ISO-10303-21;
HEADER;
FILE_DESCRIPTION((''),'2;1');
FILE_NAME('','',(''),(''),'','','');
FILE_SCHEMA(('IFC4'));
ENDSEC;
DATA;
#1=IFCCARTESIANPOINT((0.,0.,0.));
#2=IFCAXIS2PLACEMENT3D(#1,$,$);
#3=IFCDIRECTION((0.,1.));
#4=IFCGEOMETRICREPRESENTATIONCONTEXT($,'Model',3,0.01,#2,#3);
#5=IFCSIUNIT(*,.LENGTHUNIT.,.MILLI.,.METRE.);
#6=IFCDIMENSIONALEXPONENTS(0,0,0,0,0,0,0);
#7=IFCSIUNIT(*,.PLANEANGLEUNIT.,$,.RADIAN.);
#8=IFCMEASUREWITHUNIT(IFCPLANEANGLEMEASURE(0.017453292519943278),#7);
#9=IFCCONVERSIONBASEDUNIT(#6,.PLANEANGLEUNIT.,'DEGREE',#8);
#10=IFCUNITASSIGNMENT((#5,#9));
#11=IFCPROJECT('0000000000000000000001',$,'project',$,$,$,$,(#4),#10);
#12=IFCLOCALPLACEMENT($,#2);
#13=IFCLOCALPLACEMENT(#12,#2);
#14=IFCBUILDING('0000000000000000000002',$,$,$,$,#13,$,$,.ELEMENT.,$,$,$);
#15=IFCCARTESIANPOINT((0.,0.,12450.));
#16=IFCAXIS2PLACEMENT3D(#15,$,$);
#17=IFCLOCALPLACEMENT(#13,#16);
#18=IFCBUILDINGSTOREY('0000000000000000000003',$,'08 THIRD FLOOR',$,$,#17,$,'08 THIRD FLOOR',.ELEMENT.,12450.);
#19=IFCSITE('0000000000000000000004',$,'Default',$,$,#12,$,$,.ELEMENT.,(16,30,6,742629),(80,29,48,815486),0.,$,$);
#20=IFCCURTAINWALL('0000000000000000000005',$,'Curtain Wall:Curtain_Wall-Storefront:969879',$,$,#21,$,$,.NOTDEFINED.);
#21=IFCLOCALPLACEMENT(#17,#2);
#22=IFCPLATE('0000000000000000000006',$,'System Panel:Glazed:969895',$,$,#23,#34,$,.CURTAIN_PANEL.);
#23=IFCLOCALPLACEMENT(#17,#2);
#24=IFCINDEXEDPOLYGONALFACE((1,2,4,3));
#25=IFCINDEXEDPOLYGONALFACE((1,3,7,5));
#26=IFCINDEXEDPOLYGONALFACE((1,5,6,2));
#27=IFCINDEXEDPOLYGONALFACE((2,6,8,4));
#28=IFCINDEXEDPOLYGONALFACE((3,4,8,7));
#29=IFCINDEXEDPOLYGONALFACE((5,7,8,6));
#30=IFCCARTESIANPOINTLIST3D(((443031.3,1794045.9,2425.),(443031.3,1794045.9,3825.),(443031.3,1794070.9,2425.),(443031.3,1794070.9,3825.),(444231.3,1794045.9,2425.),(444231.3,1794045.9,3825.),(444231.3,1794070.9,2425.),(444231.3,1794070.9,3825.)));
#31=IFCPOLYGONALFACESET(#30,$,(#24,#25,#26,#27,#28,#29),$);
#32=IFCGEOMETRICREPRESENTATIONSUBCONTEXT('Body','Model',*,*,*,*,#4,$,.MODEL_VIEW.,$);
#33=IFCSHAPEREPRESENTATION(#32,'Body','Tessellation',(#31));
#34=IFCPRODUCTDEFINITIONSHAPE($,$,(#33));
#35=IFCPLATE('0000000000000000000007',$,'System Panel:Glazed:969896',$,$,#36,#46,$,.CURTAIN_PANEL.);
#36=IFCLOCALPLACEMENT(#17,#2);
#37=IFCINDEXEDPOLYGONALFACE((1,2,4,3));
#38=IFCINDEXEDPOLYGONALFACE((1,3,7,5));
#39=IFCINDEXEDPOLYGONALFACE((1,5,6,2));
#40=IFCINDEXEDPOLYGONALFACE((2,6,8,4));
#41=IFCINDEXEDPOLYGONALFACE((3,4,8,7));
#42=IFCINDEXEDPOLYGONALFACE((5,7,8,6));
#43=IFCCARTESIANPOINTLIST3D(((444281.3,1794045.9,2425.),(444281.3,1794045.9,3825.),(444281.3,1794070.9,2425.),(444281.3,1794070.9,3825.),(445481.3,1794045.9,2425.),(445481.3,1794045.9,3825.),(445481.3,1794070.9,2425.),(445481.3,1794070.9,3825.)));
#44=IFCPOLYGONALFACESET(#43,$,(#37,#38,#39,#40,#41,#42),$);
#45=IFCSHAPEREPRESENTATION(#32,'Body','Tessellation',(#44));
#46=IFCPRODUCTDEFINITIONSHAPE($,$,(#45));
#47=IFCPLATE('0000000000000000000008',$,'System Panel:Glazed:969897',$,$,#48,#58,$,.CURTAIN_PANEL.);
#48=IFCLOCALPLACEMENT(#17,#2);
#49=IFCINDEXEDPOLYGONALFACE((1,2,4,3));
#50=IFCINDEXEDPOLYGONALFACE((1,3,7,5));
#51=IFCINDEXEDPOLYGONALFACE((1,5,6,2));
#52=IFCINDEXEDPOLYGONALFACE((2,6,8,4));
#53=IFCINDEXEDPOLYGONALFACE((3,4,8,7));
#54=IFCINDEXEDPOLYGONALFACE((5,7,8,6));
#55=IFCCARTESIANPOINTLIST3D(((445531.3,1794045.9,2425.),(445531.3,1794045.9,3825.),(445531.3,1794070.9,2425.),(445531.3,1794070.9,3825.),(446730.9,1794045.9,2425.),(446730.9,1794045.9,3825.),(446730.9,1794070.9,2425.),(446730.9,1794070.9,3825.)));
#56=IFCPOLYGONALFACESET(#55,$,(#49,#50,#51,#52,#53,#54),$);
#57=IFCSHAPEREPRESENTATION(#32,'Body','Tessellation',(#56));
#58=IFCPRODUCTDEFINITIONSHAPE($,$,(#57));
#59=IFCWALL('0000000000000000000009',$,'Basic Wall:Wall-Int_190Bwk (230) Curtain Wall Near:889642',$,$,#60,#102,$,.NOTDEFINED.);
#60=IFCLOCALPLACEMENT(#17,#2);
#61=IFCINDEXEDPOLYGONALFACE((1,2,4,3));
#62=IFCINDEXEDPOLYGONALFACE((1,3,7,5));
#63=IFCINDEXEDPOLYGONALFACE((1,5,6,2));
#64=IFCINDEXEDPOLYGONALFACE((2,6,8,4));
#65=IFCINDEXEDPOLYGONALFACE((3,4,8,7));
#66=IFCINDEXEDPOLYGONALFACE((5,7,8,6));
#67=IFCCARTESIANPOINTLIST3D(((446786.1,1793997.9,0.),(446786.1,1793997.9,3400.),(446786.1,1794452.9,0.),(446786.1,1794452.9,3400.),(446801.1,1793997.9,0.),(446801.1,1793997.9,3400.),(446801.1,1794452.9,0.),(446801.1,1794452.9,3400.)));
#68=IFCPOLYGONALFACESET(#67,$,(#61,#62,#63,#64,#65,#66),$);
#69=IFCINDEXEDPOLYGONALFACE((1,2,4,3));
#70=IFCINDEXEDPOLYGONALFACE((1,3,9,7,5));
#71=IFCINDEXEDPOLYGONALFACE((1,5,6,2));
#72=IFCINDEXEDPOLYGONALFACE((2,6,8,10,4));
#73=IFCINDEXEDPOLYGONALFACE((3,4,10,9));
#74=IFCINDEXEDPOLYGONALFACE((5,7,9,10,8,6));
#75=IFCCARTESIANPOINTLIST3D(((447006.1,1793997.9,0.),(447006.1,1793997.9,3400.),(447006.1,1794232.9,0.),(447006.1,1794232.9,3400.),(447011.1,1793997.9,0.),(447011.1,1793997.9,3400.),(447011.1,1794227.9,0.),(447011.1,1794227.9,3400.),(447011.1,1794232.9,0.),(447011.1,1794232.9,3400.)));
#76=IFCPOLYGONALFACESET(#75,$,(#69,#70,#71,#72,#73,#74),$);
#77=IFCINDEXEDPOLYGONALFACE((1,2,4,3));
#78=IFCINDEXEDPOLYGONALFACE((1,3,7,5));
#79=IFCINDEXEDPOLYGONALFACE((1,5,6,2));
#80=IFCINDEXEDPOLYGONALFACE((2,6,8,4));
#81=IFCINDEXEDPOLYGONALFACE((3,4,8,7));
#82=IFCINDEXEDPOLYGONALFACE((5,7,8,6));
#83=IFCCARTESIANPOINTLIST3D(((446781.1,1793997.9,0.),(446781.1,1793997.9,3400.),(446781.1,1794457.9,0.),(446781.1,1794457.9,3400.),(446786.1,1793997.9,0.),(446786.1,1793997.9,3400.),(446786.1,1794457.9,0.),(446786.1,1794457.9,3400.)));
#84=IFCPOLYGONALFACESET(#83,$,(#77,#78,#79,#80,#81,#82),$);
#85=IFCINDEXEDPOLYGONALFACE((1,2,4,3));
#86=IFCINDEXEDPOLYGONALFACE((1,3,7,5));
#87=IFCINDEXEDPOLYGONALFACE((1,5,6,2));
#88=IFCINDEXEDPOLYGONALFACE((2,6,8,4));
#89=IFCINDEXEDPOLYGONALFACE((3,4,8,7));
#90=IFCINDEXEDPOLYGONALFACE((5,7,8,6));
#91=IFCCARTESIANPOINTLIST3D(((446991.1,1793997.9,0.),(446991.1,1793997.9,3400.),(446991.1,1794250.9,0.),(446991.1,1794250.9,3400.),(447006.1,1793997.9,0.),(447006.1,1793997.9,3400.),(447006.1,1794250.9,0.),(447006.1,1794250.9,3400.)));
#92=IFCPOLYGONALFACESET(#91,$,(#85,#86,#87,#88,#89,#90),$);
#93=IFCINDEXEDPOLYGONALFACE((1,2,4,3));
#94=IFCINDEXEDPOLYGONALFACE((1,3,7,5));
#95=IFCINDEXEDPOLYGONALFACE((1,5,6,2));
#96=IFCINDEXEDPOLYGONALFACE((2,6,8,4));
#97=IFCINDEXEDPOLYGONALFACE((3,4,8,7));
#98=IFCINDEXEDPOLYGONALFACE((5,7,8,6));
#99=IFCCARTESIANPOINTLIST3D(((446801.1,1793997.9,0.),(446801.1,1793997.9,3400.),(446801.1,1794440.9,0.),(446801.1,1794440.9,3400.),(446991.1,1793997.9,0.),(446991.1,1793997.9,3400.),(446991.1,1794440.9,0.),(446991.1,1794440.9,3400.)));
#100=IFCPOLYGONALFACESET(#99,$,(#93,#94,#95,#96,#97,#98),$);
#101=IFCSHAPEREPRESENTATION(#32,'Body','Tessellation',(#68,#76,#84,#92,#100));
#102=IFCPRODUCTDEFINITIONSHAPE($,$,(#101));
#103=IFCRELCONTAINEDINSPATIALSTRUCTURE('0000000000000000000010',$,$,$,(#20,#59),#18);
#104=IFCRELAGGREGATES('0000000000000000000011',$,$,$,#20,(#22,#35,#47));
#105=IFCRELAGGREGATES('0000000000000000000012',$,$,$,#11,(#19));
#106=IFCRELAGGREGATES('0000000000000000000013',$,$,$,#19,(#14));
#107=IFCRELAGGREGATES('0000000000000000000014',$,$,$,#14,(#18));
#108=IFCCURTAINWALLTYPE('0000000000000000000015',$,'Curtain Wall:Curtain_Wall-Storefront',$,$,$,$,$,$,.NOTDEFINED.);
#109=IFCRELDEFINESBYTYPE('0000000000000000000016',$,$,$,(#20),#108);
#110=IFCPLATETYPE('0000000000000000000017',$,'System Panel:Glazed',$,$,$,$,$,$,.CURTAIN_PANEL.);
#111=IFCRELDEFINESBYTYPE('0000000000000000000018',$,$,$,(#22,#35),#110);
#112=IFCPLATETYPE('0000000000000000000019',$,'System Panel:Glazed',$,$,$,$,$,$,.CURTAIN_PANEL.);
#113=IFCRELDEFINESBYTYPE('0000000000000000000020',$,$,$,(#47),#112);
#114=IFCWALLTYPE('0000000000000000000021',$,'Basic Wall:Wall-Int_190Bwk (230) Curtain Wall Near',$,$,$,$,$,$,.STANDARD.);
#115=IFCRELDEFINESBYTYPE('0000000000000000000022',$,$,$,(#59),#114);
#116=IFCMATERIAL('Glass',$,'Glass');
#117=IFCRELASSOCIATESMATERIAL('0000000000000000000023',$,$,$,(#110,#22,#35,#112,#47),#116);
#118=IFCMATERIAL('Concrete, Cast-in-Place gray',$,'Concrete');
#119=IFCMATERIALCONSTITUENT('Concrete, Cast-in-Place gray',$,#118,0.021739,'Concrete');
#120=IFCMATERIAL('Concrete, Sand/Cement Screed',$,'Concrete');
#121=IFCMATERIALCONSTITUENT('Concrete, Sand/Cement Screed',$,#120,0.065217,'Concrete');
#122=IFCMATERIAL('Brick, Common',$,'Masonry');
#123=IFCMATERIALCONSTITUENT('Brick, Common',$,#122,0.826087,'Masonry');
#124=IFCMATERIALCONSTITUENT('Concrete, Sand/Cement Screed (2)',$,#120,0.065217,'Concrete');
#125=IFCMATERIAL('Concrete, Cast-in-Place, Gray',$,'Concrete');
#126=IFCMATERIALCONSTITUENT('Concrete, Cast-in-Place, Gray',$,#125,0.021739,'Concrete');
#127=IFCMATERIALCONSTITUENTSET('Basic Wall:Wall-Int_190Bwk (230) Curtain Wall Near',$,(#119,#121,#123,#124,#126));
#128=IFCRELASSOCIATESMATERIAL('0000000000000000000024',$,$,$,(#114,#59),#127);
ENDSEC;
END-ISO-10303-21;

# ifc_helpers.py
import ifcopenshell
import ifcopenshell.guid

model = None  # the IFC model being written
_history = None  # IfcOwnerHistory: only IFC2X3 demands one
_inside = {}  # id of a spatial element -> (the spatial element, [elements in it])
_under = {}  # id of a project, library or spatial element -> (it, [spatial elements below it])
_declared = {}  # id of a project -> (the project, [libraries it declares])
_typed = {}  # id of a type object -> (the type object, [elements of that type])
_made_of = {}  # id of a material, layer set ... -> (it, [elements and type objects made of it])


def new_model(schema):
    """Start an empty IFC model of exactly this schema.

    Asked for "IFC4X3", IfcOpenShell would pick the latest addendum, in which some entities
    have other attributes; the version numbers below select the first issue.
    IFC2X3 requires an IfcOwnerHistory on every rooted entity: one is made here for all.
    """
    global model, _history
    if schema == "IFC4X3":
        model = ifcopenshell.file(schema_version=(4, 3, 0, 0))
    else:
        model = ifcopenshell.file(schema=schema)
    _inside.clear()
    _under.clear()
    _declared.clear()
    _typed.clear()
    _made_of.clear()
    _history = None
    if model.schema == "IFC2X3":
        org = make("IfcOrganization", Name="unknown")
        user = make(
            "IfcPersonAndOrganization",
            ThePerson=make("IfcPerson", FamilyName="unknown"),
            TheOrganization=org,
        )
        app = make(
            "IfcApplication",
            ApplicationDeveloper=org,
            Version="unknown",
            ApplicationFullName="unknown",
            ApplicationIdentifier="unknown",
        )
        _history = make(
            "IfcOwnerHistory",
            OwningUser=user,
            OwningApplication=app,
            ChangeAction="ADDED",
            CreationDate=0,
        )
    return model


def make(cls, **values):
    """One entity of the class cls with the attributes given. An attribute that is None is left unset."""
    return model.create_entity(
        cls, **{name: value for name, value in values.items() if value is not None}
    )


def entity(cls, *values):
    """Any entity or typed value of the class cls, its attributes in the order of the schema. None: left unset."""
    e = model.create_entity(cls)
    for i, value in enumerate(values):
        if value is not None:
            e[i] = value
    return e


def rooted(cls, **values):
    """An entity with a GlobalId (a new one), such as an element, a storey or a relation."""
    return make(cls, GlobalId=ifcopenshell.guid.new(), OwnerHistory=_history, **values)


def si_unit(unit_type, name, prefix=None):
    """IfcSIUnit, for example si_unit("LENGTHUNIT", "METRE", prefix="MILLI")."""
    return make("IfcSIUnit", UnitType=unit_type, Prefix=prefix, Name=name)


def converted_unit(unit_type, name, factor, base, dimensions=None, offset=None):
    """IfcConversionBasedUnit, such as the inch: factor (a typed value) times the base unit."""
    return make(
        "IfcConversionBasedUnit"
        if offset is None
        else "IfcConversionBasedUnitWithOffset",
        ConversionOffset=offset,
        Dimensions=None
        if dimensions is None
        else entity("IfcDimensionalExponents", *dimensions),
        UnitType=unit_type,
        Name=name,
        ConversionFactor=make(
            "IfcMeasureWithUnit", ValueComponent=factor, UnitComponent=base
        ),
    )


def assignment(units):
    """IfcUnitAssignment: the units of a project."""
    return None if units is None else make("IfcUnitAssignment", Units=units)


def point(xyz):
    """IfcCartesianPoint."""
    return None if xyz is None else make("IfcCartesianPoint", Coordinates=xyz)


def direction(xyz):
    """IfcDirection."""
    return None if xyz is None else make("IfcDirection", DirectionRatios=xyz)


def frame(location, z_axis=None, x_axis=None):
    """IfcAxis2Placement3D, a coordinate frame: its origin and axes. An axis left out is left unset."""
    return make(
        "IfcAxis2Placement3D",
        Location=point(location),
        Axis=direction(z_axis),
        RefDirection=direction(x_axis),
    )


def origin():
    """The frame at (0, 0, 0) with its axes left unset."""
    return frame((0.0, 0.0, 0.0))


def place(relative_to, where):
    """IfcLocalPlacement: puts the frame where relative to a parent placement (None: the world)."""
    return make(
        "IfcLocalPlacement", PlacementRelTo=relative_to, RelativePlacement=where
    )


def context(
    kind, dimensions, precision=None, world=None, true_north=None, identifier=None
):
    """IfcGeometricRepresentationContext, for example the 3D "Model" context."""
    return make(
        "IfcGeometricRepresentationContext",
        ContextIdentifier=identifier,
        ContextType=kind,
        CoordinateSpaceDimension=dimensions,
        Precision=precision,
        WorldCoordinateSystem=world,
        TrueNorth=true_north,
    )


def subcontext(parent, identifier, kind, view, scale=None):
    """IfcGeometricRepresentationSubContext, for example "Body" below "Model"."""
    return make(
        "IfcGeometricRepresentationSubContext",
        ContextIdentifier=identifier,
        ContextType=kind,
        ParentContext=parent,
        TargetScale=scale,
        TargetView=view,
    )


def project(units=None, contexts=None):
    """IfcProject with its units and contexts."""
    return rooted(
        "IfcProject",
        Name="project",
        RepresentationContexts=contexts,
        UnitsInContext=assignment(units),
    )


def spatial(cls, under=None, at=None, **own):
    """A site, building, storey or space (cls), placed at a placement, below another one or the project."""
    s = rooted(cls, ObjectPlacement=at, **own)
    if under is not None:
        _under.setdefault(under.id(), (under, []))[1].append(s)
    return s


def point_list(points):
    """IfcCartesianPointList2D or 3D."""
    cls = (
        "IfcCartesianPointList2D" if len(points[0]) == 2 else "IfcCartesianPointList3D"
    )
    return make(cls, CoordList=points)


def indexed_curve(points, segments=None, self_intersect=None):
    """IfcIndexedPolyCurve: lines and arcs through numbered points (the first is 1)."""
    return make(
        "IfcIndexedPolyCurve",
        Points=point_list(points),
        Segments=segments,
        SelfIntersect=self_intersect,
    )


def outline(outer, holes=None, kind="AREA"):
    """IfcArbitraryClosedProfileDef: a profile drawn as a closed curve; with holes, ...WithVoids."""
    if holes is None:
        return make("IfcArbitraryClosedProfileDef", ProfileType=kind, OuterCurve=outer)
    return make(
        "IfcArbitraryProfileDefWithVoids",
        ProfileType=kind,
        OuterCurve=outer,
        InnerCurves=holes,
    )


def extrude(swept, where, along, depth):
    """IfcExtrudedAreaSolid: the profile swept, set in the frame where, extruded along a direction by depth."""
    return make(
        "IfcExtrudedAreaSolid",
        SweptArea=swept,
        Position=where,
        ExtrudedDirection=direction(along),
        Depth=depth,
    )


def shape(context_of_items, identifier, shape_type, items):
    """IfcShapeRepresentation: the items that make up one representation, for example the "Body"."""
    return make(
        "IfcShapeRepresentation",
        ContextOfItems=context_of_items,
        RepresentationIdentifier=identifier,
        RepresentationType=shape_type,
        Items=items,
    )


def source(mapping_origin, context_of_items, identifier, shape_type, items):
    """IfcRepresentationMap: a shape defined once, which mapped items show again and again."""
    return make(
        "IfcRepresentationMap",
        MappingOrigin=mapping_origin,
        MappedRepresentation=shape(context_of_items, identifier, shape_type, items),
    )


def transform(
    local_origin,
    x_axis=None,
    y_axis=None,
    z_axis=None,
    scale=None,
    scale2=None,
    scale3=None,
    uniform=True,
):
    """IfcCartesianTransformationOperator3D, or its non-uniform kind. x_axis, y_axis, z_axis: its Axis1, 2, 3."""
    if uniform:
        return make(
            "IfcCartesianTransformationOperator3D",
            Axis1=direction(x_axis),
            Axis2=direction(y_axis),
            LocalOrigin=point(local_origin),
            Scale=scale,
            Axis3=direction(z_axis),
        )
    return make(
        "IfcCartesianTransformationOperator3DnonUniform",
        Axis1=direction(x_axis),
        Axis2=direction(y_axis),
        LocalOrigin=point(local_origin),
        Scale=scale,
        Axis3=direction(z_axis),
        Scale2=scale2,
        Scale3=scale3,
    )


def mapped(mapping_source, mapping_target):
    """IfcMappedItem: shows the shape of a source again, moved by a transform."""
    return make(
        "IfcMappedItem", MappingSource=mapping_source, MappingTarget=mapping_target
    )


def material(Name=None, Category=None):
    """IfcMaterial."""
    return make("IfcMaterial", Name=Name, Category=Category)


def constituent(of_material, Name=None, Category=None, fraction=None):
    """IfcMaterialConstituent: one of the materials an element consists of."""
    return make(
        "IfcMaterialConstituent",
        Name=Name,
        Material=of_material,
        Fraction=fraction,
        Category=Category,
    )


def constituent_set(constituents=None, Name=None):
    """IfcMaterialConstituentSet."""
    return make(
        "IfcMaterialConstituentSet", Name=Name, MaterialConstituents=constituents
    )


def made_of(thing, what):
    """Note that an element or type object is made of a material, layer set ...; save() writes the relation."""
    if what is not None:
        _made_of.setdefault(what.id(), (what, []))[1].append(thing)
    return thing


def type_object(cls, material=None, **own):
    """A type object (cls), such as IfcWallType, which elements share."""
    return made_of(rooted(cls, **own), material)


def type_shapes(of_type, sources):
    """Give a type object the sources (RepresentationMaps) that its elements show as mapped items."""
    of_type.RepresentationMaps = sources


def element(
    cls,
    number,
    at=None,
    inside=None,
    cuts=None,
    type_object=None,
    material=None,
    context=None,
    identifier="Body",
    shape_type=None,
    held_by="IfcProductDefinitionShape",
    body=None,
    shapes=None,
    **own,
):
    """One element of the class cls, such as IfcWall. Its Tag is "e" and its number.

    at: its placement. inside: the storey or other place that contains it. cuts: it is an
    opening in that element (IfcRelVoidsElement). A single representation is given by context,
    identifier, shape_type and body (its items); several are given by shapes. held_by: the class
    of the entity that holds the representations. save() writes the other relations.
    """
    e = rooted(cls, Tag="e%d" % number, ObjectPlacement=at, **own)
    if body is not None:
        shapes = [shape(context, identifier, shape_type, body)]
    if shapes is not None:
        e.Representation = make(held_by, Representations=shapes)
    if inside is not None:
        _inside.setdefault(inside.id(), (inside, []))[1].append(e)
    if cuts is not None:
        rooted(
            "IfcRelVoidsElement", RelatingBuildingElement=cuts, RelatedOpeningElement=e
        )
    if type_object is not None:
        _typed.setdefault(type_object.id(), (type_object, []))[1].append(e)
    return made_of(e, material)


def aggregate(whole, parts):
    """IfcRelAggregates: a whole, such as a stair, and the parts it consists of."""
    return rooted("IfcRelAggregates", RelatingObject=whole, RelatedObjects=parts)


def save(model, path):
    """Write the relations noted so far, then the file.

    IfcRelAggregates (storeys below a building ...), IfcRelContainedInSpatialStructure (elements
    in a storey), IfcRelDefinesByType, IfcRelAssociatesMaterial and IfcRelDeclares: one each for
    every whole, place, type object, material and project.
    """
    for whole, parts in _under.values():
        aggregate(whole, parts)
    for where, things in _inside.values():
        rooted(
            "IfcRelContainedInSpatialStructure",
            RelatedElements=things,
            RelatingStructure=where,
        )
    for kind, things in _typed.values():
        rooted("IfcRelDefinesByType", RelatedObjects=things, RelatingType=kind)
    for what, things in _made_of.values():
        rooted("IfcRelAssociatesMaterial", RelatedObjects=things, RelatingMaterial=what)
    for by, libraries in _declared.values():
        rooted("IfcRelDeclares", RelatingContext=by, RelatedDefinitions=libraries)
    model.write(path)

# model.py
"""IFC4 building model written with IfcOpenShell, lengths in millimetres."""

from ifc_helpers import new_model, entity, si_unit, converted_unit, direction, frame, origin, place, context, subcontext, project, spatial, indexed_curve, outline, extrude, source, transform, mapped, material, constituent, constituent_set, type_object, type_shapes, element, aggregate, save


model = new_model("IFC4")

# Units and contexts
model_context = context("Model", 3, precision=0.01, world=origin(), true_north=direction((0.0, 1.0)))
body_context = subcontext(model_context, "Body", "Model", "MODEL_VIEW")
ifc_project = project(units=[si_unit("LENGTHUNIT", "METRE", prefix="MILLI"), converted_unit("PLANEANGLEUNIT", "DEGREE", entity("IfcPlaneAngleMeasure", 0.017453292519943278), si_unit("PLANEANGLEUNIT", "RADIAN"), dimensions=[0, 0, 0, 0, 0, 0, 0])], contexts=[model_context])

# Site, building, storey
site_placement = place(None, origin())
site = spatial("IfcSite", under=ifc_project, at=site_placement, Name="Default", CompositionType="ELEMENT", RefLatitude=(16, 30, 6, 742629), RefLongitude=(80, 29, 48, 815486), RefElevation=0.0)
building_placement = place(site_placement, origin())
building = spatial("IfcBuilding", under=site, at=building_placement, CompositionType="ELEMENT")
storey_placement = place(building_placement, frame((0.0, 0.0, 12450.0)))
storey = spatial("IfcBuildingStorey", under=building, at=storey_placement, Name="08 THIRD FLOOR", LongName="08 THIRD FLOOR", CompositionType="ELEMENT", Elevation=12450.0)

# Curtain wall
curtain_wall_type = type_object("IfcCurtainWallType", Name="Curtain Wall:Curtain_Wall-Storefront", PredefinedType="NOTDEFINED")
curtain_wall_placement = place(storey_placement, frame((0.0, 0.0, -12450.0)))
curtain_wall = element("IfcCurtainWall", 1, at=curtain_wall_placement, inside=storey, type_object=curtain_wall_type, Name="Curtain Wall:Curtain_Wall-Storefront:969879", PredefinedType="NOTDEFINED")
ifc_material_1 = material(Name="Glass", Category="Glass")

# Plates
plate_type_1 = type_object("IfcPlateType", Name="System Panel:Glazed", PredefinedType="CURTAIN_PANEL", material=ifc_material_1)
shared_shape_1 = source(origin(), body_context, "Body", "SweptSolid", [
    extrude(outline(indexed_curve([(-12.5, -600.0), (12.5, -600.0), (12.5, 600.0), (-12.5, 600.0), (-12.5, -600.0)], self_intersect=False)), frame((0.0, -37.0, 0.0), z_axis=(0.0, 0.0, 1.0), x_axis=(0.0, 1.0, 0.0)), (0.0, 0.0, 1.0), 1400.0),
])
type_shapes(plate_type_1, [shared_shape_1])
plate_1_placement = place(curtain_wall_placement, frame((443631.3, 1794095.4, 14875.0)))
plate_1 = element("IfcPlate", 2, at=plate_1_placement, type_object=plate_type_1, material=ifc_material_1, Name="System Panel:Glazed:969895", PredefinedType="CURTAIN_PANEL", context=body_context, shape_type="MappedRepresentation", body=[
    mapped(shared_shape_1, transform((0.0, 0.0, 0.0), scale=1.0)),
])
plate_2_placement = place(curtain_wall_placement, frame((444881.3, 1794095.4, 14875.0)))
plate_2 = element("IfcPlate", 3, at=plate_2_placement, type_object=plate_type_1, material=ifc_material_1, Name="System Panel:Glazed:969896", PredefinedType="CURTAIN_PANEL", context=body_context, shape_type="MappedRepresentation", body=[
    mapped(shared_shape_1, transform((0.0, 0.0, 0.0), scale=1.0)),
])
plate_type_2 = type_object("IfcPlateType", Name="System Panel:Glazed", PredefinedType="CURTAIN_PANEL", material=ifc_material_1)
shared_shape_2 = source(origin(), body_context, "Body", "SweptSolid", [
    extrude(outline(indexed_curve([(-12.5, -599.8), (12.5, -599.8), (12.5, 599.8), (-12.5, 599.8), (-12.5, -599.8)], self_intersect=False)), frame((0.0, -37.0, 0.0), z_axis=(0.0, 0.0, 1.0), x_axis=(0.0, 1.0, 0.0)), (0.0, 0.0, 1.0), 1400.0),
])
type_shapes(plate_type_2, [shared_shape_2])
plate_3_placement = place(curtain_wall_placement, frame((446131.1, 1794095.4, 14875.0)))
plate_3 = element("IfcPlate", 4, at=plate_3_placement, type_object=plate_type_2, material=ifc_material_1, Name="System Panel:Glazed:969897", PredefinedType="CURTAIN_PANEL", context=body_context, shape_type="MappedRepresentation", body=[
    mapped(shared_shape_2, transform((0.0, 0.0, 0.0), scale=1.0)),
])
aggregate(curtain_wall, [plate_1, plate_2, plate_3])

# Wall
ifc_material_2 = material(Name="Concrete, Cast-in-Place gray", Category="Concrete")
ifc_constituent_1 = constituent(ifc_material_2, Name="Concrete, Cast-in-Place gray", Category="Concrete", fraction=0.021739)
ifc_material_3 = material(Name="Concrete, Sand/Cement Screed", Category="Concrete")
ifc_constituent_2 = constituent(ifc_material_3, Name="Concrete, Sand/Cement Screed", Category="Concrete", fraction=0.065217)
ifc_material_4 = material(Name="Brick, Common", Category="Masonry")
ifc_constituent_3 = constituent(ifc_material_4, Name="Brick, Common", Category="Masonry", fraction=0.826087)
ifc_constituent_4 = constituent(ifc_material_3, Name="Concrete, Sand/Cement Screed (2)", Category="Concrete", fraction=0.065217)
ifc_material_5 = material(Name="Concrete, Cast-in-Place, Gray", Category="Concrete")
ifc_constituent_5 = constituent(ifc_material_5, Name="Concrete, Cast-in-Place, Gray", Category="Concrete", fraction=0.021739)
ifc_constituent_set_1 = constituent_set(constituents=[ifc_constituent_1, ifc_constituent_2, ifc_constituent_3, ifc_constituent_4, ifc_constituent_5], Name="Basic Wall:Wall-Int_190Bwk (230) Curtain Wall Near")
wall_type = type_object("IfcWallType", Name="Basic Wall:Wall-Int_190Bwk (230) Curtain Wall Near", PredefinedType="STANDARD", material=ifc_constituent_set_1)
wall_placement = place(storey_placement, frame((446896.1, 1793997.9, 0.0), z_axis=(0.0, 0.0, 1.0), x_axis=(0.0, 1.0, 0.0)))
element("IfcWall", 5, at=wall_placement, inside=storey, type_object=wall_type, material=ifc_constituent_set_1, Name="Basic Wall:Wall-Int_190Bwk (230) Curtain Wall Near:889642", PredefinedType="NOTDEFINED", context=body_context, shape_type="SweptSolid", body=[
    extrude(outline(indexed_curve([(-227.5, -7.5), (227.5, -7.5), (227.5, 7.5), (-227.5, 7.5), (-227.5, -7.5)], self_intersect=False)), frame((227.5, 102.5, 0.0)), (0.0, 0.0, 1.0), 3400.0),
    extrude(outline(indexed_curve([(90.0, -2.0), (95.0, -2.0), (95.0, 3.0), (-140.0, 3.0), (-140.0, -2.0), (90.0, -2.0)], self_intersect=False)), frame((140.0, -113.0, 0.0)), (0.0, 0.0, 1.0), 3400.0),
    extrude(outline(indexed_curve([(-2.5, -230.0), (2.5, -230.0), (2.5, 230.0), (-2.5, 230.0), (-2.5, -230.0)], self_intersect=False)), frame((230.0, 112.5, 0.0), z_axis=(0.0, 0.0, 1.0), x_axis=(0.0, -1.0, 0.0)), (0.0, 0.0, 1.0), 3400.0),
    extrude(outline(indexed_curve([(-126.5, -7.5), (126.5, -7.5), (126.5, 7.5), (-126.5, 7.5), (-126.5, -7.5)], self_intersect=False)), frame((126.5, -102.5, 0.0)), (0.0, 0.0, 1.0), 3400.0),
    extrude(outline(indexed_curve([(-221.5, -95.0), (221.5, -95.0), (221.5, 95.0), (-221.5, 95.0), (-221.5, -95.0)], self_intersect=False)), frame((221.5, 0.0, 0.0)), (0.0, 0.0, 1.0), 3400.0),
])

save(model, "model.ifc")
